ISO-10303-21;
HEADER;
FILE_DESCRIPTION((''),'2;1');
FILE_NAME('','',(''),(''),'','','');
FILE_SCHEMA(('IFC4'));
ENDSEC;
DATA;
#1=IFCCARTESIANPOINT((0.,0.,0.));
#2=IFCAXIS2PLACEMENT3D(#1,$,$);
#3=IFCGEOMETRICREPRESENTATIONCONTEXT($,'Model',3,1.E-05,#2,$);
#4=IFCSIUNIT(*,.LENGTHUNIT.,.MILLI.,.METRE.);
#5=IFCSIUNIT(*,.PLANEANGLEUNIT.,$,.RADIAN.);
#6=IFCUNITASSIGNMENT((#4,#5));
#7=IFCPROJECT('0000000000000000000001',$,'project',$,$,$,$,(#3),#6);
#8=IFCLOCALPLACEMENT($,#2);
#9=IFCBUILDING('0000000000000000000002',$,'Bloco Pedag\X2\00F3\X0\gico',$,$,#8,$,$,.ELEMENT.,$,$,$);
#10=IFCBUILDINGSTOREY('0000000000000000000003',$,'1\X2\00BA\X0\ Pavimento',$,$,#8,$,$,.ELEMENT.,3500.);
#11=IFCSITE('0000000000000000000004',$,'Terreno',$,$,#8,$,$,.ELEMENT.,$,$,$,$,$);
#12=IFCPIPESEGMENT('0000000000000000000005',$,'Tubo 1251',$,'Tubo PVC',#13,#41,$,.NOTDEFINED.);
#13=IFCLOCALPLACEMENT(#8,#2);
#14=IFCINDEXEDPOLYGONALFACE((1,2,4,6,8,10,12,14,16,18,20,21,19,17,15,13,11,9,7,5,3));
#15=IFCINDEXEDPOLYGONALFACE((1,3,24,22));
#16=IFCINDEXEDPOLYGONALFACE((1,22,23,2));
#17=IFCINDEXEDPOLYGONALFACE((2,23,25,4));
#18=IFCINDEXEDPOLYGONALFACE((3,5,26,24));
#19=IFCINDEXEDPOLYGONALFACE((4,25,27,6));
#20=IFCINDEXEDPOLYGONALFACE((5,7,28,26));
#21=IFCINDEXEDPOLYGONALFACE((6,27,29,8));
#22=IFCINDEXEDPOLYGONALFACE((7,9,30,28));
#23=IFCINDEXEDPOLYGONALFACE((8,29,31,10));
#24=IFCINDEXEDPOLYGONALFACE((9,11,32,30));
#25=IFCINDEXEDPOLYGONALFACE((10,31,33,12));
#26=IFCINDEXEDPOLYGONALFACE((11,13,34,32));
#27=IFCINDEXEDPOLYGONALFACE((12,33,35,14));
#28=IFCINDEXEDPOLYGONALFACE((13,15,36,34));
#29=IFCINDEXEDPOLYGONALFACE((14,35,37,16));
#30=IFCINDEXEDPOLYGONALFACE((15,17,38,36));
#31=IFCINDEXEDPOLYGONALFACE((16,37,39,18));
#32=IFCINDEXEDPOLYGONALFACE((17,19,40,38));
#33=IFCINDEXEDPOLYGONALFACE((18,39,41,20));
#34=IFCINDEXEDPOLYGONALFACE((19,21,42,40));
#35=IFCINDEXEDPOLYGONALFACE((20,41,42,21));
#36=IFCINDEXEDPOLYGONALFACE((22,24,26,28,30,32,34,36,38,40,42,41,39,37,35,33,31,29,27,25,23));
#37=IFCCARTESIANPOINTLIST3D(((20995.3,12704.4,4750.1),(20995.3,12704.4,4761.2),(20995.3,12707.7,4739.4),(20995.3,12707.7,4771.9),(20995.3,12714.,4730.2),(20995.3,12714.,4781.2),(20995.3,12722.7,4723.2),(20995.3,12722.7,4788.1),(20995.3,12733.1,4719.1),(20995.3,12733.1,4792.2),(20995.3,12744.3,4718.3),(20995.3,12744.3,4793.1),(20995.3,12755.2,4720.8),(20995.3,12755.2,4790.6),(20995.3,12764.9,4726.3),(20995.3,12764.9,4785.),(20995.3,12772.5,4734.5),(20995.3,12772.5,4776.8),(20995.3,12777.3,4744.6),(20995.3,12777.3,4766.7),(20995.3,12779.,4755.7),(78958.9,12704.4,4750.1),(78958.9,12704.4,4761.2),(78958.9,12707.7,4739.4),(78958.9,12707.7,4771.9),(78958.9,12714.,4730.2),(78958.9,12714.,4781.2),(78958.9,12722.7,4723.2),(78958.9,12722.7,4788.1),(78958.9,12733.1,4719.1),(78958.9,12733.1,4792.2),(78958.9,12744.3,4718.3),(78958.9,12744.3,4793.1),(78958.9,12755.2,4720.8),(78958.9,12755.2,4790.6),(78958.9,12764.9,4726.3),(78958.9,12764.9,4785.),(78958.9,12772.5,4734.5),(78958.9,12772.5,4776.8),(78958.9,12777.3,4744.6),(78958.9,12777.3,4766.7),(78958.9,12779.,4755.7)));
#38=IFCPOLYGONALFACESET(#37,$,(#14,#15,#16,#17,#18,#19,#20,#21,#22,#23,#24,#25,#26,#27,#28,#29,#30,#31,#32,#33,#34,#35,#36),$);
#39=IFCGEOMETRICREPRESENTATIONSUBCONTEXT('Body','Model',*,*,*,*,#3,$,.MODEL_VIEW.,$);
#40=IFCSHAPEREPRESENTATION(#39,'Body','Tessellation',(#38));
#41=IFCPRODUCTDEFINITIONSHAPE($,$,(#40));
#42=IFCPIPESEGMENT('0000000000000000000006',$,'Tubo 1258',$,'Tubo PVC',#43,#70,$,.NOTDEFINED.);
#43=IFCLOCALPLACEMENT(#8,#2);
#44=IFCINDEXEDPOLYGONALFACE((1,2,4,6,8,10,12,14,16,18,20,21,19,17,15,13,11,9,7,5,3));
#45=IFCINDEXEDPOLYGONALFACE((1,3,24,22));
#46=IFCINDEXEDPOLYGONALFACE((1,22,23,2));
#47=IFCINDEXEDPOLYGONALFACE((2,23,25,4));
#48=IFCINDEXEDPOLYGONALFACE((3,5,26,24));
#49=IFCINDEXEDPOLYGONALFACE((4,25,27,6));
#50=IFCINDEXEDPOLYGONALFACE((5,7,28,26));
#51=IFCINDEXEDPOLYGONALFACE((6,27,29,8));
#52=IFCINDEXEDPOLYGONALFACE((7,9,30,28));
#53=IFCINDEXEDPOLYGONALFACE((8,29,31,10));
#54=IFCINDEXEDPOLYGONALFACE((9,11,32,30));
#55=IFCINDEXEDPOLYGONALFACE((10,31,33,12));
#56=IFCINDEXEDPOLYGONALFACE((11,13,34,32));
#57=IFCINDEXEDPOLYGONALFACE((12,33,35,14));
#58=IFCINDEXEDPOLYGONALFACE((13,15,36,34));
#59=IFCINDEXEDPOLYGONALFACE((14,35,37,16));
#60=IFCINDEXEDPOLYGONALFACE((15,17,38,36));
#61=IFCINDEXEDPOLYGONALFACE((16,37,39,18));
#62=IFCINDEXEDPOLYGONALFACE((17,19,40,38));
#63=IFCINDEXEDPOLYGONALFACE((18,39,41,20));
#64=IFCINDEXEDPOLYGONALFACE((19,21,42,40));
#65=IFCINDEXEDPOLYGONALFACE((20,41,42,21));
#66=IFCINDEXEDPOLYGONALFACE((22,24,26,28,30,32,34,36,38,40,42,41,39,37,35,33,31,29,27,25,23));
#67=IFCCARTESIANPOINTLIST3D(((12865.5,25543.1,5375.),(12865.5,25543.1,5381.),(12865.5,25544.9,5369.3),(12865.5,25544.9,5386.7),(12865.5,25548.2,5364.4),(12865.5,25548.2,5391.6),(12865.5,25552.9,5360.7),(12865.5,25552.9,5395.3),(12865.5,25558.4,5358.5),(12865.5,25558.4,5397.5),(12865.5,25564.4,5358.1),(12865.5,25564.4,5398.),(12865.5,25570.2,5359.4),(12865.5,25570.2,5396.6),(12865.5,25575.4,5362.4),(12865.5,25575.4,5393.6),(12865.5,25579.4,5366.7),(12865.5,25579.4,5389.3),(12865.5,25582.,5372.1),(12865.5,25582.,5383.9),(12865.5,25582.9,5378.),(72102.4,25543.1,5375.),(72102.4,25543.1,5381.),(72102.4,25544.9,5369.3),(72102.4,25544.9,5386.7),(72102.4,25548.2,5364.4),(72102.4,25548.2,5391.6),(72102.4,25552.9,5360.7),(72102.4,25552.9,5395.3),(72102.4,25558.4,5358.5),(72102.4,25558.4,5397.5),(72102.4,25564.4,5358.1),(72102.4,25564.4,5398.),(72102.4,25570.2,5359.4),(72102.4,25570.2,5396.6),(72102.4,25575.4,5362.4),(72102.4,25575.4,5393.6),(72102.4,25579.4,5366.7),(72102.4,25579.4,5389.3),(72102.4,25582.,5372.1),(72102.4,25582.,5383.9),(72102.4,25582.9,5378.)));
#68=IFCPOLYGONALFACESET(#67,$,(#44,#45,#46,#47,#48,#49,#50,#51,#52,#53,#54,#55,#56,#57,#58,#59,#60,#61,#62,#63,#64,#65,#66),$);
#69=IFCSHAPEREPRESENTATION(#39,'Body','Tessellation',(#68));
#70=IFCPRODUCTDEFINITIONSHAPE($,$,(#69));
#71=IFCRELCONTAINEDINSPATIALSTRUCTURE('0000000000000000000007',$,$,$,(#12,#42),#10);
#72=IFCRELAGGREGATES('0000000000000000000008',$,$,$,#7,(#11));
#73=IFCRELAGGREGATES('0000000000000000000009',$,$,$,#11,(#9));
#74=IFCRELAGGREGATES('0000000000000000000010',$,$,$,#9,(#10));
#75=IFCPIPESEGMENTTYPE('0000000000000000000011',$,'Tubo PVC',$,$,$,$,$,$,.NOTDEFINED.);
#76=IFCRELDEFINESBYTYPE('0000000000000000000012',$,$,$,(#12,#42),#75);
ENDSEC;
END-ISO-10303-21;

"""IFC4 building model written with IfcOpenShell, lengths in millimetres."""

from ifc_helpers import new_model, si_unit, frame, origin, origin_2d, place, context, subcontext, project, spatial, circle, extrude, type_object, element, save


model = new_model("IFC4")

# Units and contexts
model_context = context("Model", 3, precision=1e-05, world=origin())
body_context = subcontext(model_context, "Body", "Model", "MODEL_VIEW")
ifc_project = project(units=[si_unit("LENGTHUNIT", "METRE", prefix="MILLI"), si_unit("PLANEANGLEUNIT", "RADIAN")], contexts=[model_context])

# Site, building, storey
placement = place(None, origin())
site = spatial("IfcSite", under=ifc_project, at=placement, Name="Terreno", CompositionType="ELEMENT")
building = spatial("IfcBuilding", under=site, at=placement, Name="Bloco Pedagógico", CompositionType="ELEMENT")
storey = spatial("IfcBuildingStorey", under=building, at=placement, Name="1º Pavimento", CompositionType="ELEMENT", Elevation=3500.0)

# Pipe segments
pipe_segment_type = type_object("IfcPipeSegmentType", Name="Tubo PVC", PredefinedType="NOTDEFINED")
pipe_segment_1_placement = place(None, frame((20995.3, 12741.5, 4755.7), z_axis=(1.0, 0.0, 0.0), x_axis=(0.0, 1.0, 0.0)))
element("IfcPipeSegment", 1, at=pipe_segment_1_placement, inside=storey, type_object=pipe_segment_type, Name="Tubo 1251", ObjectType="Tubo PVC", PredefinedType="NOTDEFINED", context=body_context, shape_type="SweptSolid", body=[
    extrude(circle(Radius=37.5, at=origin_2d()), None, (0.0, 0.0, 1.0), 57963.7),
])
pipe_segment_2_placement = place(None, frame((12865.5, 25562.9, 5378.0), z_axis=(1.0, 0.0, 0.0), x_axis=(0.0, 1.0, 0.0)))
element("IfcPipeSegment", 2, at=pipe_segment_2_placement, inside=storey, type_object=pipe_segment_type, Name="Tubo 1258", ObjectType="Tubo PVC", PredefinedType="NOTDEFINED", context=body_context, shape_type="SweptSolid", body=[
    extrude(circle(Radius=20.0, at=origin_2d()), None, (0.0, 0.0, 1.0), 59236.9),
])

save(model, "model.ifc")
